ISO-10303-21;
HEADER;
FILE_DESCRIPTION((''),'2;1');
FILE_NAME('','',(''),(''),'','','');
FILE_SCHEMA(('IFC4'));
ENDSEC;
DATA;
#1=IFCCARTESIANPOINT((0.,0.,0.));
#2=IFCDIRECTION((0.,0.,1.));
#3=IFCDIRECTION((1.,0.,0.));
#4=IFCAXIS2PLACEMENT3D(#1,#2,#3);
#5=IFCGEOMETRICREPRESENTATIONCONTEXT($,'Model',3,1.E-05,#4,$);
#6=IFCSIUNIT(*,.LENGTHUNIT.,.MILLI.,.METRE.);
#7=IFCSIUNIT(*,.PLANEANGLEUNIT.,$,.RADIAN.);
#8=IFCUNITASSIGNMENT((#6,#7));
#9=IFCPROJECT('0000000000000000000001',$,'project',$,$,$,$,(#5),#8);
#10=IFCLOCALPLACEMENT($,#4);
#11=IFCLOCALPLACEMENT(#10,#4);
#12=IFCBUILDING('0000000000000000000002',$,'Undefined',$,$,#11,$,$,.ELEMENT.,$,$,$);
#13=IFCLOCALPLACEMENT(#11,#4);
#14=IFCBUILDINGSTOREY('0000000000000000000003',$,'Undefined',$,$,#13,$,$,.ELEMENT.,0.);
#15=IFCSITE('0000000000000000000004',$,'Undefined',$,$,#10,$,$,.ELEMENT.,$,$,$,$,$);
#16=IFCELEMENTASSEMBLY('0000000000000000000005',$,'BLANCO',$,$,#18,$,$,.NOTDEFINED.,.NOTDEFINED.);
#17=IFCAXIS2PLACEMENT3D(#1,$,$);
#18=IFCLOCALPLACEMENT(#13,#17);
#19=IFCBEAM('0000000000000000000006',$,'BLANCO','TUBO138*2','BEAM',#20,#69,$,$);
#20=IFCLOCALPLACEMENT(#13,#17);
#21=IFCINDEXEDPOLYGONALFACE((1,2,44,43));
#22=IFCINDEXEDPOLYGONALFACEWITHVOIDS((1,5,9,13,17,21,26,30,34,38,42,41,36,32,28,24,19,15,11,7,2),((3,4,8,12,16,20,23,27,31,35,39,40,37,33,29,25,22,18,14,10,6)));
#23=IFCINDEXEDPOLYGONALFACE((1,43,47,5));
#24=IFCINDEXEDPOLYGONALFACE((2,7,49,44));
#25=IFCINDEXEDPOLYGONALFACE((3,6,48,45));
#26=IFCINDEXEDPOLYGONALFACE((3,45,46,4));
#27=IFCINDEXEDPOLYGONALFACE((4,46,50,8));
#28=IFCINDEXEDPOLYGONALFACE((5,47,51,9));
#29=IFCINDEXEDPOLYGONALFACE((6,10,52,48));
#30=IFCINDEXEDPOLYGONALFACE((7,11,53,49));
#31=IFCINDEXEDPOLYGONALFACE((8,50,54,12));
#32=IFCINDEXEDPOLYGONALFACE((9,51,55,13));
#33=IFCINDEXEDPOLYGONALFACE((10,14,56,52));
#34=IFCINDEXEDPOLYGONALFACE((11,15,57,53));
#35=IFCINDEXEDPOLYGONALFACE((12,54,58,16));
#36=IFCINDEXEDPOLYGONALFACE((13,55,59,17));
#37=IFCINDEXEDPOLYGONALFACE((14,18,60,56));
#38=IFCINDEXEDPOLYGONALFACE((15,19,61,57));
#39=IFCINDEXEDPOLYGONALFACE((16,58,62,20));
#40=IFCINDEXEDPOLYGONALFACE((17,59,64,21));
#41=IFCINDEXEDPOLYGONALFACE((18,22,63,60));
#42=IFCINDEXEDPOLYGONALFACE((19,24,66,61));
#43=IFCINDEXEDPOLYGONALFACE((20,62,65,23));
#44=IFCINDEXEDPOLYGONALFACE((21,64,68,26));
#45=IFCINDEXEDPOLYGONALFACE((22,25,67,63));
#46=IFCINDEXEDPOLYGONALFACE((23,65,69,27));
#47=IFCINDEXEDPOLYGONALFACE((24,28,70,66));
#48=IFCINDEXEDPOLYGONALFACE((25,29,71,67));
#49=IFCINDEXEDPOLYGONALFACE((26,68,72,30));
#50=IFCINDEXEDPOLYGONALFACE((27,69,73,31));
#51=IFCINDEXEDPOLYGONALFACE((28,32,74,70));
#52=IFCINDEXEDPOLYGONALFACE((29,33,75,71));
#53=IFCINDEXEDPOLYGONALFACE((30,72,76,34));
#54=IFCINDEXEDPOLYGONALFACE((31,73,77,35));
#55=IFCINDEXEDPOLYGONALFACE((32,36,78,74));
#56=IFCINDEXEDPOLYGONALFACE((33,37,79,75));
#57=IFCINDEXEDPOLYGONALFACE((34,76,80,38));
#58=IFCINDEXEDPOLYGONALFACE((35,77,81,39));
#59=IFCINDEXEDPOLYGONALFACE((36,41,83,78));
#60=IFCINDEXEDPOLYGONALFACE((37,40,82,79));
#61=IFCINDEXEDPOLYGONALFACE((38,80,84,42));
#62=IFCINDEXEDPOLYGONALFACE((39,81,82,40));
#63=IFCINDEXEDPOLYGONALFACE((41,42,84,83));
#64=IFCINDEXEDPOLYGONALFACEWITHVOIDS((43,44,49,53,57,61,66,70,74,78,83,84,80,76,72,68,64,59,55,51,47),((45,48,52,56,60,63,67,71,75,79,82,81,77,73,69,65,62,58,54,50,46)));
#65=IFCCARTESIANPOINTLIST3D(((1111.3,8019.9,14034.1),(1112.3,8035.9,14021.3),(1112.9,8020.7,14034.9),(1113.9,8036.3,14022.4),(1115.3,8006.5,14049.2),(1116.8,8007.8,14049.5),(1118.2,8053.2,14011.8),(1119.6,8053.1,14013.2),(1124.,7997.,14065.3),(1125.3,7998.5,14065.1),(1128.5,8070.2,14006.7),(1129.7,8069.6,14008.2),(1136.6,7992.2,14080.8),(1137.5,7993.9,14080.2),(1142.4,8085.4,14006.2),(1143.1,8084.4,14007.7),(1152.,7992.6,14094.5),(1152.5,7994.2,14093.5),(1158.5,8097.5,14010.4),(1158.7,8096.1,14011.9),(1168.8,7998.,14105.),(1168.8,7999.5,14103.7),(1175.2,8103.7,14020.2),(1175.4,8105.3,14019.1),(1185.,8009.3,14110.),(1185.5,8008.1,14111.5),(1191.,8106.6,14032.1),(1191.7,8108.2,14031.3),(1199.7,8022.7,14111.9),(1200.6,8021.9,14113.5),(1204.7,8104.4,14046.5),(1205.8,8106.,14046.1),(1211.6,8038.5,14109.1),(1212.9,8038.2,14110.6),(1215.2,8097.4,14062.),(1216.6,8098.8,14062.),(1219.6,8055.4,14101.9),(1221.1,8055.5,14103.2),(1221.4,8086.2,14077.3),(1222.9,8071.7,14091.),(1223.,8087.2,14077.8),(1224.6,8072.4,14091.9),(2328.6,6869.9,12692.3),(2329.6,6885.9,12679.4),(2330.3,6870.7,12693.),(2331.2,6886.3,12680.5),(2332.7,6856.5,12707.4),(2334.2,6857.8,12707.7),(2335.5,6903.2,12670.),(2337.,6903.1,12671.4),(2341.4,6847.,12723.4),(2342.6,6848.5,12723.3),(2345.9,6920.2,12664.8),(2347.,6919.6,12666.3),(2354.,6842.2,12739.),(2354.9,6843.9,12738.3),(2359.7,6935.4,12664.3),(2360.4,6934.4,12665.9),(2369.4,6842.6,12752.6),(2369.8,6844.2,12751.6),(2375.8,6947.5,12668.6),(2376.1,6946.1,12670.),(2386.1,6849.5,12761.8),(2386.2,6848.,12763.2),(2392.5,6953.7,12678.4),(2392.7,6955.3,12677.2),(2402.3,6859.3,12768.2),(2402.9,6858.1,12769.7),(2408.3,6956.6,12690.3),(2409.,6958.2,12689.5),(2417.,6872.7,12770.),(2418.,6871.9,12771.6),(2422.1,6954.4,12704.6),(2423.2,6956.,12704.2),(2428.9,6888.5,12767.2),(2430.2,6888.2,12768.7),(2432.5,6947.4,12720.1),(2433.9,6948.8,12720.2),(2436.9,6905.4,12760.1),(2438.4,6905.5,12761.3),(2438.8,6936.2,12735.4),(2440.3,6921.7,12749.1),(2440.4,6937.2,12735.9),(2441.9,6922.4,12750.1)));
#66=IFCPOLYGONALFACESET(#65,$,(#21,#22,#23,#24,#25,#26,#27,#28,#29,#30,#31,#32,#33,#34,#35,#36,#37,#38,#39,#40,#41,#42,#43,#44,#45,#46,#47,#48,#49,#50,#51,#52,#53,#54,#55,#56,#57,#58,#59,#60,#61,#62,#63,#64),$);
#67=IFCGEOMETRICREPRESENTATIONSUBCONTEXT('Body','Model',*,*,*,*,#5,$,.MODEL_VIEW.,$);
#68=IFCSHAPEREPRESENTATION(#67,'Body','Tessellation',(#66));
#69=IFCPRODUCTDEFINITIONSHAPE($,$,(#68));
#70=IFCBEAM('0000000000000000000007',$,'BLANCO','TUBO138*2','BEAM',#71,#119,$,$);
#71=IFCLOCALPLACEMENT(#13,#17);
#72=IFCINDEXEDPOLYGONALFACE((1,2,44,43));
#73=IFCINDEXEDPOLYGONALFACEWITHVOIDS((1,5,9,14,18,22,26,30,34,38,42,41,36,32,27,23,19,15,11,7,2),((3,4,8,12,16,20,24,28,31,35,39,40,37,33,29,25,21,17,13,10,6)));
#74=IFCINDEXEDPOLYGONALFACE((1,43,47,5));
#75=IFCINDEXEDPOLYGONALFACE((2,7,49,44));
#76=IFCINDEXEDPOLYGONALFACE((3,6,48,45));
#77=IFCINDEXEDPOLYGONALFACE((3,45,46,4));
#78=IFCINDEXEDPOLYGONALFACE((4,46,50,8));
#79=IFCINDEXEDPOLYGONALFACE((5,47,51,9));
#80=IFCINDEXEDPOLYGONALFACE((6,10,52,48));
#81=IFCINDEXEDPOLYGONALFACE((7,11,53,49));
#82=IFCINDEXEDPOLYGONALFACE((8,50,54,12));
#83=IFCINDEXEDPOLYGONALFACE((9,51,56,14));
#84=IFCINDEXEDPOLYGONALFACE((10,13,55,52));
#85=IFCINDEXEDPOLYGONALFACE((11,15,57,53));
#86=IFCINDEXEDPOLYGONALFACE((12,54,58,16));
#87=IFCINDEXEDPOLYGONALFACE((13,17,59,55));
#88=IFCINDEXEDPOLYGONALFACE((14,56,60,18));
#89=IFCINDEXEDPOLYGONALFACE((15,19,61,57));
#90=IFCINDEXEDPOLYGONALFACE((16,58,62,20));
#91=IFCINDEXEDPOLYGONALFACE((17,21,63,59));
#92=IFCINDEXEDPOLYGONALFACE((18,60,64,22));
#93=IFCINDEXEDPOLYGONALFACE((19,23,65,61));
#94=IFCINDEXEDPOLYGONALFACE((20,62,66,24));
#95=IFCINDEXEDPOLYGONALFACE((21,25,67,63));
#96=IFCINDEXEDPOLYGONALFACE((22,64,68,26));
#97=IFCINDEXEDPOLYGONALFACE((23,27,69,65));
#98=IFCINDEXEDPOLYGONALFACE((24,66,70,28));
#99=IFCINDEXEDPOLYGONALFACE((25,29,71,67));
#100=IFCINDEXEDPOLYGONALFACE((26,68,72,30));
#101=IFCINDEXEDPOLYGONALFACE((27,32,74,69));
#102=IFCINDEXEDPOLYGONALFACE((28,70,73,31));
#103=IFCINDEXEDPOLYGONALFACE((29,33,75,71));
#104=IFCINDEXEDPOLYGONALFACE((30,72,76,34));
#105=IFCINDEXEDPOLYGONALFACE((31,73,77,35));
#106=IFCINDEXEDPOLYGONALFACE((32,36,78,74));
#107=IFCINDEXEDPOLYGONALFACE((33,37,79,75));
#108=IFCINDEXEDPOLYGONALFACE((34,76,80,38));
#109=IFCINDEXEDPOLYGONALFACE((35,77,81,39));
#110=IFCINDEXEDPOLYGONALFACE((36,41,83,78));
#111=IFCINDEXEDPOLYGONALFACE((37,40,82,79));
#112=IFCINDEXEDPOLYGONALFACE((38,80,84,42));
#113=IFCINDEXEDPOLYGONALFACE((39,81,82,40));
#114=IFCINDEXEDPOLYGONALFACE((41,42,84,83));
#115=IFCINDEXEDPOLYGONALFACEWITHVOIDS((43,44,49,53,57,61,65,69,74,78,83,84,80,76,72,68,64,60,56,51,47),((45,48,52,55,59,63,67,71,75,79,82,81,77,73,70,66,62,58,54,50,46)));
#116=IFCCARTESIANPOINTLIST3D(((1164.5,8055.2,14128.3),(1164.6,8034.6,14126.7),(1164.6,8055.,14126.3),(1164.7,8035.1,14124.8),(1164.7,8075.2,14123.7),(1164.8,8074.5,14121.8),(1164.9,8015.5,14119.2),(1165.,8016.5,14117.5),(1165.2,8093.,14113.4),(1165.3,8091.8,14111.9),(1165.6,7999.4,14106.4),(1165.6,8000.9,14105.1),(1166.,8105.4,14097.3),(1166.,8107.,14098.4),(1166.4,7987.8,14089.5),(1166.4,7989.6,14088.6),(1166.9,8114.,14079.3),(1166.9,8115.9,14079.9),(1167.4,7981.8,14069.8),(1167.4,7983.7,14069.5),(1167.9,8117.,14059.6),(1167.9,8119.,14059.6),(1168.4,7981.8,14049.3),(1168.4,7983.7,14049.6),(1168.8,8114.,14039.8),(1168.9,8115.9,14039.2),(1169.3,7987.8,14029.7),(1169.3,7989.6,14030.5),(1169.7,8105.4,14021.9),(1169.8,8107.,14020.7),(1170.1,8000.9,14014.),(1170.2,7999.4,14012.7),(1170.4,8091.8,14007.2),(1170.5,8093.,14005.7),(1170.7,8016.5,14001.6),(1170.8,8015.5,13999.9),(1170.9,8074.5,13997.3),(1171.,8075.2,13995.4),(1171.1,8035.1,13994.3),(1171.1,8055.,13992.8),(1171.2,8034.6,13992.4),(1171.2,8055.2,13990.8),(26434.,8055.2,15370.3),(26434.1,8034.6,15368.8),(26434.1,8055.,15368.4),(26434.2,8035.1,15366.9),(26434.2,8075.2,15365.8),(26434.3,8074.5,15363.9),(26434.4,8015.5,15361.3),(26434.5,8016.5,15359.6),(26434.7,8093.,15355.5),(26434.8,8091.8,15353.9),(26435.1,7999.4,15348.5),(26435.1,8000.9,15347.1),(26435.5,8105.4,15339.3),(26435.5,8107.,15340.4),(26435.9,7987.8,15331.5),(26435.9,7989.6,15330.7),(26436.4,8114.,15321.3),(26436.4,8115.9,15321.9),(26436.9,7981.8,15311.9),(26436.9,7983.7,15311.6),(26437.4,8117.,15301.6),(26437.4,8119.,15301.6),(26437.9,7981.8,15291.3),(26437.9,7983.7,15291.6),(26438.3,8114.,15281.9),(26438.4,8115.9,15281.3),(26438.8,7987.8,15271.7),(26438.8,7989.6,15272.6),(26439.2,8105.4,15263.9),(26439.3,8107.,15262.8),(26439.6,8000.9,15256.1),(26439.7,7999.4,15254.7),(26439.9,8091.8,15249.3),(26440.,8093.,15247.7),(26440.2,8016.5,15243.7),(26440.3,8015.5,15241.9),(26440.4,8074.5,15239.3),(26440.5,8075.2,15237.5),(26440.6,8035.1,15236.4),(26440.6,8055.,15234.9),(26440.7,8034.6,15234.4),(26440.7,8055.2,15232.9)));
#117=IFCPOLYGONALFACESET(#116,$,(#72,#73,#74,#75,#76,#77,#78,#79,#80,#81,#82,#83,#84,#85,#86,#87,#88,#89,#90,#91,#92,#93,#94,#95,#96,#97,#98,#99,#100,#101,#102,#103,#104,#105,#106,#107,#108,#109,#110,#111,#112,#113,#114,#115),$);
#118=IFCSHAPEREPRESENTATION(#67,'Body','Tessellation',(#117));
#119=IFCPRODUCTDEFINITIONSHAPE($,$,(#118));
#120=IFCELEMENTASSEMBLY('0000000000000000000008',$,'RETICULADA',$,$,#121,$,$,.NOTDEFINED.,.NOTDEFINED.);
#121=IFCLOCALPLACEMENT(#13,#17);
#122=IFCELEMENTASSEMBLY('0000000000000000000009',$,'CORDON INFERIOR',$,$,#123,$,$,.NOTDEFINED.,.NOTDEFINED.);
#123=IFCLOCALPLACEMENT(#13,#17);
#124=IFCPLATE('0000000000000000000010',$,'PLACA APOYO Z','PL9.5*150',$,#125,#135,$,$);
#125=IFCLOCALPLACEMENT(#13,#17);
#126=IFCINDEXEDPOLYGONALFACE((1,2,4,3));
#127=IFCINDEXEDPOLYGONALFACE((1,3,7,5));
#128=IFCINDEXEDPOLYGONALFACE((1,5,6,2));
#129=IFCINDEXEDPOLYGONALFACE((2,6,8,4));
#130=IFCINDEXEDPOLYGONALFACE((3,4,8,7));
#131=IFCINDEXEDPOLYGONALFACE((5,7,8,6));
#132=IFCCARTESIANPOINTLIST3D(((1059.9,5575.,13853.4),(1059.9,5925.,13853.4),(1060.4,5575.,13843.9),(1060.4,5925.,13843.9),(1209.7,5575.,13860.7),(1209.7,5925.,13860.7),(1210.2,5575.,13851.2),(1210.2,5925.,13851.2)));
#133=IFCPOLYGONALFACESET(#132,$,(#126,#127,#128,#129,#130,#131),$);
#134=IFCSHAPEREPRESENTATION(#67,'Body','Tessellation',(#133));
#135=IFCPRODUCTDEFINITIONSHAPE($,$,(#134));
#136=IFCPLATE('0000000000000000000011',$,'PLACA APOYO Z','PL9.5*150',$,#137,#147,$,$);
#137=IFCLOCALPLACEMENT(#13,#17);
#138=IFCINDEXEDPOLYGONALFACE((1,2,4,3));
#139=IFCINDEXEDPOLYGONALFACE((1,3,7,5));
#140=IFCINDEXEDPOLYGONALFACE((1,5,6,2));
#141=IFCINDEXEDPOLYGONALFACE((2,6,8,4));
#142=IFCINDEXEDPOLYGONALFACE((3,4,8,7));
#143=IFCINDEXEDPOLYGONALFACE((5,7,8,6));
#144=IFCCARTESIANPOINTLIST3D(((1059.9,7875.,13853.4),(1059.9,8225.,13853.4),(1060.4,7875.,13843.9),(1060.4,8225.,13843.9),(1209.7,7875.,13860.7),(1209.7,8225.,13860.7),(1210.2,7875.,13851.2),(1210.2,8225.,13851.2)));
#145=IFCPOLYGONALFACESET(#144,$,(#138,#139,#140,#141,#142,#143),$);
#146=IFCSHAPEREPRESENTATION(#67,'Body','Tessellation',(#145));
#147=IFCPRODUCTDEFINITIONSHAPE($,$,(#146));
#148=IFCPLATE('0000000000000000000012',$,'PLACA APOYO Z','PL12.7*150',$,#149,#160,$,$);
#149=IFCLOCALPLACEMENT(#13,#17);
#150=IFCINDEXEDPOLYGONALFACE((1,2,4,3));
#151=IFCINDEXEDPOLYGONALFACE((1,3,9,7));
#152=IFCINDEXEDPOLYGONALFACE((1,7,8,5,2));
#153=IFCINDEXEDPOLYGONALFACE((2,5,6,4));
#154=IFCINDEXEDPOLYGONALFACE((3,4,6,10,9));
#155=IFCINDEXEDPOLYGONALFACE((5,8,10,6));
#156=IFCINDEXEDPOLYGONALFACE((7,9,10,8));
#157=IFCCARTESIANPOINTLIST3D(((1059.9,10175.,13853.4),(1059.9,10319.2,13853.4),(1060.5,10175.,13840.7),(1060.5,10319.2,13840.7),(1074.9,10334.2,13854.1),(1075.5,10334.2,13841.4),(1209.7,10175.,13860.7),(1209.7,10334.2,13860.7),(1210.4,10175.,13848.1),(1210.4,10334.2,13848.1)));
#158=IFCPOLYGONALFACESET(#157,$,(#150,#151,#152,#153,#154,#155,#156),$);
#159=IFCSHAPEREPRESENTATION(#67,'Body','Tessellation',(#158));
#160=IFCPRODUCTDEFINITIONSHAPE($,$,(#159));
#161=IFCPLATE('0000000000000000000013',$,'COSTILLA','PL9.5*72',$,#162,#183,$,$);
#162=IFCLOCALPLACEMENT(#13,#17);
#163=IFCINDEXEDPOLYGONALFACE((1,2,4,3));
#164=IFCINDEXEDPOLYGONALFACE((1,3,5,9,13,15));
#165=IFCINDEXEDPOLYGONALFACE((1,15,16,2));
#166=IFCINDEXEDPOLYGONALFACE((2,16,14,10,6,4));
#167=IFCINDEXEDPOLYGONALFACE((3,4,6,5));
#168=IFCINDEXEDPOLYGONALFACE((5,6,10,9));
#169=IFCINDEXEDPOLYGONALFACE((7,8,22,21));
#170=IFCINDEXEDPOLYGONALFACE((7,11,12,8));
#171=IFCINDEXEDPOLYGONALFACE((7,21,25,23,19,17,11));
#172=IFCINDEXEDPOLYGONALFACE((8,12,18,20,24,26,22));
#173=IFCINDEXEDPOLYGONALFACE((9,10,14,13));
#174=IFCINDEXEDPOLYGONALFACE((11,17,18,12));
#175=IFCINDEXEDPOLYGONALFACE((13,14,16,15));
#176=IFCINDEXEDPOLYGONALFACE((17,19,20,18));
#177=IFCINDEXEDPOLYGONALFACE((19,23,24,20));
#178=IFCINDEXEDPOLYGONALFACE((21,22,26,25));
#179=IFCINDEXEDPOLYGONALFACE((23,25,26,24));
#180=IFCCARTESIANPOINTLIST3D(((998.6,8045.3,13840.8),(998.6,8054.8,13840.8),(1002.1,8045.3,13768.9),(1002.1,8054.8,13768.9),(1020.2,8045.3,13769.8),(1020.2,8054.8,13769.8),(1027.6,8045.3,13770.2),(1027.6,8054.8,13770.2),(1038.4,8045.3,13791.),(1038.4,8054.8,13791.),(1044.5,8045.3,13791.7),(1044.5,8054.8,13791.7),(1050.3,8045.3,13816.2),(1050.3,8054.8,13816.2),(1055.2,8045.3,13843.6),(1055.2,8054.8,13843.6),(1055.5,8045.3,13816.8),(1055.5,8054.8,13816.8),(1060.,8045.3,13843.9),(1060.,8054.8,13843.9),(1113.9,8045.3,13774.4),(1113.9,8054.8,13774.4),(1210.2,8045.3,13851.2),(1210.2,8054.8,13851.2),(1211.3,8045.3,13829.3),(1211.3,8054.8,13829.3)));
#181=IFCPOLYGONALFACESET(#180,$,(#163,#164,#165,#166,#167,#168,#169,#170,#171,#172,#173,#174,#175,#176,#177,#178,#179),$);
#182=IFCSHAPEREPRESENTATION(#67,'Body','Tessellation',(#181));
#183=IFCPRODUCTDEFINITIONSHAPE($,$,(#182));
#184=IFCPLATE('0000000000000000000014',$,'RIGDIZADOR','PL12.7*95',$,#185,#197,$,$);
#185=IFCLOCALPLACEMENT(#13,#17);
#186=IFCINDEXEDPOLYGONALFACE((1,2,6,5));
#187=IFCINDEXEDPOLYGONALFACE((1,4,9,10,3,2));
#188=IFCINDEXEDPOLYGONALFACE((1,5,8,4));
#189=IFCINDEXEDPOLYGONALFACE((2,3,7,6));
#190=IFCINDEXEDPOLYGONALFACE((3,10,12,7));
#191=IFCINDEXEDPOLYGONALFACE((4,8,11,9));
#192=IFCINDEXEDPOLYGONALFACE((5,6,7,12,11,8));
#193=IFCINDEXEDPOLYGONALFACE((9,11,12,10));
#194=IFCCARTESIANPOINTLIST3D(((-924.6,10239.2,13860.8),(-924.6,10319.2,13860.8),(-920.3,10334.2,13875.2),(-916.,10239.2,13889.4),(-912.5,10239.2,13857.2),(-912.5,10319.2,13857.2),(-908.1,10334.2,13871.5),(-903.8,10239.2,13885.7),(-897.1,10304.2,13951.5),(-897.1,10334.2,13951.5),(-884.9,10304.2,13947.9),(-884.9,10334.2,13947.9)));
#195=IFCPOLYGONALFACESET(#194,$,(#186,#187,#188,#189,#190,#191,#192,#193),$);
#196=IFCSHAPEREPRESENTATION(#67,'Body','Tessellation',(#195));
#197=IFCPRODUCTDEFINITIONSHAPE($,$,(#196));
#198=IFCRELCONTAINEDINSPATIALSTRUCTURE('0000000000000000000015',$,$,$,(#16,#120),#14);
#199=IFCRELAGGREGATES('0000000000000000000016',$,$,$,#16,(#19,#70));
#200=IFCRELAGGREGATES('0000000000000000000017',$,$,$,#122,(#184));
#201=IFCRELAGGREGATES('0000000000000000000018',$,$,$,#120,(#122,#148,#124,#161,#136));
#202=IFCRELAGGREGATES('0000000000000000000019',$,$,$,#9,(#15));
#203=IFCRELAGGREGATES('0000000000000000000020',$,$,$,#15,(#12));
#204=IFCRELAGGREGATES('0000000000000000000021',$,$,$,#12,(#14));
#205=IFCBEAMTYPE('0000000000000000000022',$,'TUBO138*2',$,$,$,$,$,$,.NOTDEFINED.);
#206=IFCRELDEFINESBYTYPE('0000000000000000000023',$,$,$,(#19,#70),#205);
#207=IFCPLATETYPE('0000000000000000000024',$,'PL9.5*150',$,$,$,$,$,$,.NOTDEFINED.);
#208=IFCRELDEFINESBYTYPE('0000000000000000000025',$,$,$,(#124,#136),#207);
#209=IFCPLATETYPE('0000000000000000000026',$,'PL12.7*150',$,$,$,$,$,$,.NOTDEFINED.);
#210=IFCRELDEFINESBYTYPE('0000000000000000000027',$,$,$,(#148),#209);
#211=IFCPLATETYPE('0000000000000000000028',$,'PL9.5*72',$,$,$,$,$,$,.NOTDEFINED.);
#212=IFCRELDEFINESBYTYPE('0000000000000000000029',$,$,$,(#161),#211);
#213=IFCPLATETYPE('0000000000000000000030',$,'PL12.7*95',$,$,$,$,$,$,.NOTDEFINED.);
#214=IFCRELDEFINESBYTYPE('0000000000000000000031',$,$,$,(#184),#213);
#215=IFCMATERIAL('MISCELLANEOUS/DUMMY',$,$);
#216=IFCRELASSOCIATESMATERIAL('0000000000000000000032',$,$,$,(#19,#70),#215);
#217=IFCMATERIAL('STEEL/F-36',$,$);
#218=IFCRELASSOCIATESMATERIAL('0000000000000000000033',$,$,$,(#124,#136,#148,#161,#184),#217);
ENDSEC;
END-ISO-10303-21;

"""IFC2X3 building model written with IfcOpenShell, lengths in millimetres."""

from ifc_helpers import new_model, si_unit, frame, origin_with_axes, origin_2d_with_axis, place, context, subcontext, project, spatial, polyline, hollow_circle, outline, extrude, boolean, material, type_object, element, aggregate, save


model = new_model("IFC2X3")

# Units and contexts
model_context = context("Model", 3, precision=1e-05, world=origin_with_axes())
body_context = subcontext(model_context, "Body", "Model", "MODEL_VIEW")
ifc_project = project(units=[si_unit("LENGTHUNIT", "METRE", prefix="MILLI"), si_unit("PLANEANGLEUNIT", "RADIAN")], contexts=[model_context])

# Site, building, storey
site_placement = place(None, origin_with_axes())
site = spatial("IfcSite", under=ifc_project, at=site_placement, Name="Undefined", CompositionType="ELEMENT")
building_placement = place(site_placement, origin_with_axes())
building = spatial("IfcBuilding", under=site, at=building_placement, Name="Undefined", CompositionType="ELEMENT")
storey_placement = place(building_placement, origin_with_axes())
storey = spatial("IfcBuildingStorey", under=building, at=storey_placement, Name="Undefined", CompositionType="ELEMENT", Elevation=0.0)

# Element assembly, beams
assembly_1_placement = place(storey_placement, origin_with_axes())
assembly_1 = element("IfcElementAssembly", 1, at=assembly_1_placement, inside=storey, Name="BLANCO", AssemblyPlace="NOTDEFINED", PredefinedType="NOTDEFINED")
ifc_material_1 = material(Name="MISCELLANEOUS/DUMMY")
beam_type_1 = type_object("IfcBeamType", Name="TUBO138*2", PredefinedType="NOTDEFINED")
beam_1_placement = place(assembly_1_placement, frame((1167.9, 8050.0, 14059.6), z_axis=(-0.423552, 0.461316, -0.77961), x_axis=(0.567282, -0.535899, -0.625303)))
beam_1 = element("IfcBeam", 2, at=beam_1_placement, type_object=beam_type_1, material=ifc_material_1, Name="BLANCO", Description="TUBO138*2", ObjectType="BEAM", context=body_context, shape_type="SweptSolid", body=[
    extrude(hollow_circle(Radius=69.0, WallThickness=2.0, at=origin_2d_with_axis()), frame((2145.9, 0.0, 0.0), z_axis=(-1.0, 0.0, 0.0), x_axis=(0.0, -1.0, 0.0)), (0.0, 0.0, 1.0), 2145.9),
])
beam_2_placement = place(assembly_1_placement, frame((1167.9, 8050.0, 14059.6), z_axis=(0.049093, 0.0, -0.998794), x_axis=(0.998794, 0.0, 0.049093)))
beam_2 = element("IfcBeam", 3, at=beam_2_placement, type_object=beam_type_1, material=ifc_material_1, Name="BLANCO", Description="TUBO138*2", ObjectType="BEAM", context=body_context, shape_type="SweptSolid", body=[
    extrude(hollow_circle(Radius=69.0, WallThickness=2.0, at=origin_2d_with_axis()), frame((25300.0, 0.0, 0.0), z_axis=(-1.0, 0.0, 0.0), x_axis=(0.0, -1.0, 0.0)), (0.0, 0.0, 1.0), 25300.0),
])
aggregate(assembly_1, [beam_1, beam_2])

# Element assemblies, plates
assembly_2_placement = place(storey_placement, origin_with_axes())
assembly_2 = element("IfcElementAssembly", 4, at=assembly_2_placement, inside=storey, Name="RETICULADA", AssemblyPlace="NOTDEFINED", PredefinedType="NOTDEFINED")
assembly_3_placement = place(assembly_2_placement, origin_with_axes())
assembly_3 = element("IfcElementAssembly", 5, at=assembly_3_placement, Name="CORDON INFERIOR", AssemblyPlace="NOTDEFINED", PredefinedType="NOTDEFINED")
ifc_material_2 = material(Name="STEEL/F-36")
plate_type_1 = type_object("IfcPlateType", Name="PL9.5*150", PredefinedType="NOTDEFINED")
plate_1_placement = place(assembly_2_placement, frame((1210.0, 5925.0, 13856.0), z_axis=(-0.049094, 0.000004, 0.998794), x_axis=(-0.998794, 0.0, -0.049094)))
plate_1 = element("IfcPlate", 6, at=plate_1_placement, type_object=plate_type_1, material=ifc_material_2, Name="PLACA APOYO Z", Description="PL9.5*150", context=body_context, shape_type="SweptSolid", body=[
    extrude(outline(polyline([(0.0, 0.0), (150.0, 0.0), (150.0, 350.0), (0.0, 350.0), (0.0, 0.0)])), frame((0.0, 0.0, -4.8), z_axis=(0.0, 0.0, 1.0), x_axis=(1.0, 0.0, 0.0)), (0.0, 0.0, 1.0), 9.5),
])
plate_2_placement = place(assembly_2_placement, frame((1210.0, 8225.0, 13856.0), z_axis=(-0.049094, 0.000004, 0.998794), x_axis=(-0.998794, 0.0, -0.049094)))
plate_2 = element("IfcPlate", 7, at=plate_2_placement, type_object=plate_type_1, material=ifc_material_2, Name="PLACA APOYO Z", Description="PL9.5*150", context=body_context, shape_type="SweptSolid", body=[
    extrude(outline(polyline([(0.0, 0.0), (150.0, 0.0), (150.0, 350.0), (0.0, 350.0), (0.0, 0.0)])), frame((0.0, 0.0, -4.8), z_axis=(0.0, 0.0, 1.0), x_axis=(1.0, 0.0, 0.0)), (0.0, 0.0, 1.0), 9.5),
])

# Plates
plate_type_2 = type_object("IfcPlateType", Name="PL12.7*150", PredefinedType="NOTDEFINED")
plate_3_placement = place(assembly_2_placement, frame((1210.1, 10175.0, 13854.4), z_axis=(0.049094, 0.00001, -0.998794), x_axis=(-0.998794, 0.0, -0.049094)))
plate_3 = element("IfcPlate", 8, at=plate_3_placement, type_object=plate_type_2, material=ifc_material_2, Name="PLACA APOYO Z", Description="PL12.7*150", context=body_context, shape_type="SweptSolid", body=[
    extrude(outline(polyline([(0.0, 0.0), (150.0, 0.0), (150.0, 144.2), (135.0, 159.2), (0.0, 159.2), (0.0, 0.0)])), frame((0.0, 0.0, -6.3), z_axis=(0.0, 0.0, 1.0), x_axis=(1.0, 0.0, 0.0)), (0.0, 0.0, 1.0), 12.7),
])
plate_type_3 = type_object("IfcPlateType", Name="PL9.5*72", PredefinedType="NOTDEFINED")
plate_4_placement = place(assembly_2_placement, frame((1210.2, 8050.0, 13851.2), z_axis=(0.0, -1.0, 0.0), x_axis=(-0.998794, 0.0, -0.049094)))
plate_4 = element("IfcPlate", 9, at=plate_4_placement, type_object=plate_type_3, material=ifc_material_2, Name="COSTILLA", Description="PL9.5*72", context=body_context, shape_type="CSG", body=[
    boolean("DIFFERENCE", extrude(outline(polyline([(0.0, 0.0), (211.9, 0.0), (211.9, 72.0), (100.0, 72.0), (0.0, 22.0), (0.0, 0.0)])), frame((0.0, 0.0, -4.8), z_axis=(0.0, 0.0, 1.0), x_axis=(1.0, 0.0, 0.0)), (0.0, 0.0, 1.0), 9.5), extrude(hollow_circle(Radius=109.5, WallThickness=4.8, at=origin_2d_with_axis()), frame((259.6, -9.5, -200.0), z_axis=(0.0, 0.0, 1.0), x_axis=(-1.0, 0.0, 0.0)), (0.0, 0.0, 1.0), 400.0)),
])
plate_type_4 = type_object("IfcPlateType", Name="PL12.7*95", PredefinedType="NOTDEFINED")
plate_5_placement = place(assembly_3_placement, frame((-891.0, 10334.2, 13949.7), z_axis=(-0.956743, 0.0, 0.290936), x_axis=(-0.290936, 0.0, -0.956743)))
plate_5 = element("IfcPlate", 10, at=plate_5_placement, type_object=plate_type_4, material=ifc_material_2, Name="RIGDIZADOR", Description="PL12.7*95", context=body_context, shape_type="SweptSolid", body=[
    extrude(outline(polyline([(0.0, 0.0), (79.8, 0.0), (94.8, 15.0), (94.8, 95.0), (65.0, 95.0), (0.0, 30.0), (0.0, 0.0)])), frame((0.0, 0.0, -6.3), z_axis=(0.0, 0.0, 1.0), x_axis=(1.0, 0.0, 0.0)), (0.0, 0.0, 1.0), 12.7),
])
aggregate(assembly_3, [plate_5])

aggregate(assembly_2, [assembly_3, plate_3, plate_1, plate_4, plate_2])

save(model, "model.ifc")
